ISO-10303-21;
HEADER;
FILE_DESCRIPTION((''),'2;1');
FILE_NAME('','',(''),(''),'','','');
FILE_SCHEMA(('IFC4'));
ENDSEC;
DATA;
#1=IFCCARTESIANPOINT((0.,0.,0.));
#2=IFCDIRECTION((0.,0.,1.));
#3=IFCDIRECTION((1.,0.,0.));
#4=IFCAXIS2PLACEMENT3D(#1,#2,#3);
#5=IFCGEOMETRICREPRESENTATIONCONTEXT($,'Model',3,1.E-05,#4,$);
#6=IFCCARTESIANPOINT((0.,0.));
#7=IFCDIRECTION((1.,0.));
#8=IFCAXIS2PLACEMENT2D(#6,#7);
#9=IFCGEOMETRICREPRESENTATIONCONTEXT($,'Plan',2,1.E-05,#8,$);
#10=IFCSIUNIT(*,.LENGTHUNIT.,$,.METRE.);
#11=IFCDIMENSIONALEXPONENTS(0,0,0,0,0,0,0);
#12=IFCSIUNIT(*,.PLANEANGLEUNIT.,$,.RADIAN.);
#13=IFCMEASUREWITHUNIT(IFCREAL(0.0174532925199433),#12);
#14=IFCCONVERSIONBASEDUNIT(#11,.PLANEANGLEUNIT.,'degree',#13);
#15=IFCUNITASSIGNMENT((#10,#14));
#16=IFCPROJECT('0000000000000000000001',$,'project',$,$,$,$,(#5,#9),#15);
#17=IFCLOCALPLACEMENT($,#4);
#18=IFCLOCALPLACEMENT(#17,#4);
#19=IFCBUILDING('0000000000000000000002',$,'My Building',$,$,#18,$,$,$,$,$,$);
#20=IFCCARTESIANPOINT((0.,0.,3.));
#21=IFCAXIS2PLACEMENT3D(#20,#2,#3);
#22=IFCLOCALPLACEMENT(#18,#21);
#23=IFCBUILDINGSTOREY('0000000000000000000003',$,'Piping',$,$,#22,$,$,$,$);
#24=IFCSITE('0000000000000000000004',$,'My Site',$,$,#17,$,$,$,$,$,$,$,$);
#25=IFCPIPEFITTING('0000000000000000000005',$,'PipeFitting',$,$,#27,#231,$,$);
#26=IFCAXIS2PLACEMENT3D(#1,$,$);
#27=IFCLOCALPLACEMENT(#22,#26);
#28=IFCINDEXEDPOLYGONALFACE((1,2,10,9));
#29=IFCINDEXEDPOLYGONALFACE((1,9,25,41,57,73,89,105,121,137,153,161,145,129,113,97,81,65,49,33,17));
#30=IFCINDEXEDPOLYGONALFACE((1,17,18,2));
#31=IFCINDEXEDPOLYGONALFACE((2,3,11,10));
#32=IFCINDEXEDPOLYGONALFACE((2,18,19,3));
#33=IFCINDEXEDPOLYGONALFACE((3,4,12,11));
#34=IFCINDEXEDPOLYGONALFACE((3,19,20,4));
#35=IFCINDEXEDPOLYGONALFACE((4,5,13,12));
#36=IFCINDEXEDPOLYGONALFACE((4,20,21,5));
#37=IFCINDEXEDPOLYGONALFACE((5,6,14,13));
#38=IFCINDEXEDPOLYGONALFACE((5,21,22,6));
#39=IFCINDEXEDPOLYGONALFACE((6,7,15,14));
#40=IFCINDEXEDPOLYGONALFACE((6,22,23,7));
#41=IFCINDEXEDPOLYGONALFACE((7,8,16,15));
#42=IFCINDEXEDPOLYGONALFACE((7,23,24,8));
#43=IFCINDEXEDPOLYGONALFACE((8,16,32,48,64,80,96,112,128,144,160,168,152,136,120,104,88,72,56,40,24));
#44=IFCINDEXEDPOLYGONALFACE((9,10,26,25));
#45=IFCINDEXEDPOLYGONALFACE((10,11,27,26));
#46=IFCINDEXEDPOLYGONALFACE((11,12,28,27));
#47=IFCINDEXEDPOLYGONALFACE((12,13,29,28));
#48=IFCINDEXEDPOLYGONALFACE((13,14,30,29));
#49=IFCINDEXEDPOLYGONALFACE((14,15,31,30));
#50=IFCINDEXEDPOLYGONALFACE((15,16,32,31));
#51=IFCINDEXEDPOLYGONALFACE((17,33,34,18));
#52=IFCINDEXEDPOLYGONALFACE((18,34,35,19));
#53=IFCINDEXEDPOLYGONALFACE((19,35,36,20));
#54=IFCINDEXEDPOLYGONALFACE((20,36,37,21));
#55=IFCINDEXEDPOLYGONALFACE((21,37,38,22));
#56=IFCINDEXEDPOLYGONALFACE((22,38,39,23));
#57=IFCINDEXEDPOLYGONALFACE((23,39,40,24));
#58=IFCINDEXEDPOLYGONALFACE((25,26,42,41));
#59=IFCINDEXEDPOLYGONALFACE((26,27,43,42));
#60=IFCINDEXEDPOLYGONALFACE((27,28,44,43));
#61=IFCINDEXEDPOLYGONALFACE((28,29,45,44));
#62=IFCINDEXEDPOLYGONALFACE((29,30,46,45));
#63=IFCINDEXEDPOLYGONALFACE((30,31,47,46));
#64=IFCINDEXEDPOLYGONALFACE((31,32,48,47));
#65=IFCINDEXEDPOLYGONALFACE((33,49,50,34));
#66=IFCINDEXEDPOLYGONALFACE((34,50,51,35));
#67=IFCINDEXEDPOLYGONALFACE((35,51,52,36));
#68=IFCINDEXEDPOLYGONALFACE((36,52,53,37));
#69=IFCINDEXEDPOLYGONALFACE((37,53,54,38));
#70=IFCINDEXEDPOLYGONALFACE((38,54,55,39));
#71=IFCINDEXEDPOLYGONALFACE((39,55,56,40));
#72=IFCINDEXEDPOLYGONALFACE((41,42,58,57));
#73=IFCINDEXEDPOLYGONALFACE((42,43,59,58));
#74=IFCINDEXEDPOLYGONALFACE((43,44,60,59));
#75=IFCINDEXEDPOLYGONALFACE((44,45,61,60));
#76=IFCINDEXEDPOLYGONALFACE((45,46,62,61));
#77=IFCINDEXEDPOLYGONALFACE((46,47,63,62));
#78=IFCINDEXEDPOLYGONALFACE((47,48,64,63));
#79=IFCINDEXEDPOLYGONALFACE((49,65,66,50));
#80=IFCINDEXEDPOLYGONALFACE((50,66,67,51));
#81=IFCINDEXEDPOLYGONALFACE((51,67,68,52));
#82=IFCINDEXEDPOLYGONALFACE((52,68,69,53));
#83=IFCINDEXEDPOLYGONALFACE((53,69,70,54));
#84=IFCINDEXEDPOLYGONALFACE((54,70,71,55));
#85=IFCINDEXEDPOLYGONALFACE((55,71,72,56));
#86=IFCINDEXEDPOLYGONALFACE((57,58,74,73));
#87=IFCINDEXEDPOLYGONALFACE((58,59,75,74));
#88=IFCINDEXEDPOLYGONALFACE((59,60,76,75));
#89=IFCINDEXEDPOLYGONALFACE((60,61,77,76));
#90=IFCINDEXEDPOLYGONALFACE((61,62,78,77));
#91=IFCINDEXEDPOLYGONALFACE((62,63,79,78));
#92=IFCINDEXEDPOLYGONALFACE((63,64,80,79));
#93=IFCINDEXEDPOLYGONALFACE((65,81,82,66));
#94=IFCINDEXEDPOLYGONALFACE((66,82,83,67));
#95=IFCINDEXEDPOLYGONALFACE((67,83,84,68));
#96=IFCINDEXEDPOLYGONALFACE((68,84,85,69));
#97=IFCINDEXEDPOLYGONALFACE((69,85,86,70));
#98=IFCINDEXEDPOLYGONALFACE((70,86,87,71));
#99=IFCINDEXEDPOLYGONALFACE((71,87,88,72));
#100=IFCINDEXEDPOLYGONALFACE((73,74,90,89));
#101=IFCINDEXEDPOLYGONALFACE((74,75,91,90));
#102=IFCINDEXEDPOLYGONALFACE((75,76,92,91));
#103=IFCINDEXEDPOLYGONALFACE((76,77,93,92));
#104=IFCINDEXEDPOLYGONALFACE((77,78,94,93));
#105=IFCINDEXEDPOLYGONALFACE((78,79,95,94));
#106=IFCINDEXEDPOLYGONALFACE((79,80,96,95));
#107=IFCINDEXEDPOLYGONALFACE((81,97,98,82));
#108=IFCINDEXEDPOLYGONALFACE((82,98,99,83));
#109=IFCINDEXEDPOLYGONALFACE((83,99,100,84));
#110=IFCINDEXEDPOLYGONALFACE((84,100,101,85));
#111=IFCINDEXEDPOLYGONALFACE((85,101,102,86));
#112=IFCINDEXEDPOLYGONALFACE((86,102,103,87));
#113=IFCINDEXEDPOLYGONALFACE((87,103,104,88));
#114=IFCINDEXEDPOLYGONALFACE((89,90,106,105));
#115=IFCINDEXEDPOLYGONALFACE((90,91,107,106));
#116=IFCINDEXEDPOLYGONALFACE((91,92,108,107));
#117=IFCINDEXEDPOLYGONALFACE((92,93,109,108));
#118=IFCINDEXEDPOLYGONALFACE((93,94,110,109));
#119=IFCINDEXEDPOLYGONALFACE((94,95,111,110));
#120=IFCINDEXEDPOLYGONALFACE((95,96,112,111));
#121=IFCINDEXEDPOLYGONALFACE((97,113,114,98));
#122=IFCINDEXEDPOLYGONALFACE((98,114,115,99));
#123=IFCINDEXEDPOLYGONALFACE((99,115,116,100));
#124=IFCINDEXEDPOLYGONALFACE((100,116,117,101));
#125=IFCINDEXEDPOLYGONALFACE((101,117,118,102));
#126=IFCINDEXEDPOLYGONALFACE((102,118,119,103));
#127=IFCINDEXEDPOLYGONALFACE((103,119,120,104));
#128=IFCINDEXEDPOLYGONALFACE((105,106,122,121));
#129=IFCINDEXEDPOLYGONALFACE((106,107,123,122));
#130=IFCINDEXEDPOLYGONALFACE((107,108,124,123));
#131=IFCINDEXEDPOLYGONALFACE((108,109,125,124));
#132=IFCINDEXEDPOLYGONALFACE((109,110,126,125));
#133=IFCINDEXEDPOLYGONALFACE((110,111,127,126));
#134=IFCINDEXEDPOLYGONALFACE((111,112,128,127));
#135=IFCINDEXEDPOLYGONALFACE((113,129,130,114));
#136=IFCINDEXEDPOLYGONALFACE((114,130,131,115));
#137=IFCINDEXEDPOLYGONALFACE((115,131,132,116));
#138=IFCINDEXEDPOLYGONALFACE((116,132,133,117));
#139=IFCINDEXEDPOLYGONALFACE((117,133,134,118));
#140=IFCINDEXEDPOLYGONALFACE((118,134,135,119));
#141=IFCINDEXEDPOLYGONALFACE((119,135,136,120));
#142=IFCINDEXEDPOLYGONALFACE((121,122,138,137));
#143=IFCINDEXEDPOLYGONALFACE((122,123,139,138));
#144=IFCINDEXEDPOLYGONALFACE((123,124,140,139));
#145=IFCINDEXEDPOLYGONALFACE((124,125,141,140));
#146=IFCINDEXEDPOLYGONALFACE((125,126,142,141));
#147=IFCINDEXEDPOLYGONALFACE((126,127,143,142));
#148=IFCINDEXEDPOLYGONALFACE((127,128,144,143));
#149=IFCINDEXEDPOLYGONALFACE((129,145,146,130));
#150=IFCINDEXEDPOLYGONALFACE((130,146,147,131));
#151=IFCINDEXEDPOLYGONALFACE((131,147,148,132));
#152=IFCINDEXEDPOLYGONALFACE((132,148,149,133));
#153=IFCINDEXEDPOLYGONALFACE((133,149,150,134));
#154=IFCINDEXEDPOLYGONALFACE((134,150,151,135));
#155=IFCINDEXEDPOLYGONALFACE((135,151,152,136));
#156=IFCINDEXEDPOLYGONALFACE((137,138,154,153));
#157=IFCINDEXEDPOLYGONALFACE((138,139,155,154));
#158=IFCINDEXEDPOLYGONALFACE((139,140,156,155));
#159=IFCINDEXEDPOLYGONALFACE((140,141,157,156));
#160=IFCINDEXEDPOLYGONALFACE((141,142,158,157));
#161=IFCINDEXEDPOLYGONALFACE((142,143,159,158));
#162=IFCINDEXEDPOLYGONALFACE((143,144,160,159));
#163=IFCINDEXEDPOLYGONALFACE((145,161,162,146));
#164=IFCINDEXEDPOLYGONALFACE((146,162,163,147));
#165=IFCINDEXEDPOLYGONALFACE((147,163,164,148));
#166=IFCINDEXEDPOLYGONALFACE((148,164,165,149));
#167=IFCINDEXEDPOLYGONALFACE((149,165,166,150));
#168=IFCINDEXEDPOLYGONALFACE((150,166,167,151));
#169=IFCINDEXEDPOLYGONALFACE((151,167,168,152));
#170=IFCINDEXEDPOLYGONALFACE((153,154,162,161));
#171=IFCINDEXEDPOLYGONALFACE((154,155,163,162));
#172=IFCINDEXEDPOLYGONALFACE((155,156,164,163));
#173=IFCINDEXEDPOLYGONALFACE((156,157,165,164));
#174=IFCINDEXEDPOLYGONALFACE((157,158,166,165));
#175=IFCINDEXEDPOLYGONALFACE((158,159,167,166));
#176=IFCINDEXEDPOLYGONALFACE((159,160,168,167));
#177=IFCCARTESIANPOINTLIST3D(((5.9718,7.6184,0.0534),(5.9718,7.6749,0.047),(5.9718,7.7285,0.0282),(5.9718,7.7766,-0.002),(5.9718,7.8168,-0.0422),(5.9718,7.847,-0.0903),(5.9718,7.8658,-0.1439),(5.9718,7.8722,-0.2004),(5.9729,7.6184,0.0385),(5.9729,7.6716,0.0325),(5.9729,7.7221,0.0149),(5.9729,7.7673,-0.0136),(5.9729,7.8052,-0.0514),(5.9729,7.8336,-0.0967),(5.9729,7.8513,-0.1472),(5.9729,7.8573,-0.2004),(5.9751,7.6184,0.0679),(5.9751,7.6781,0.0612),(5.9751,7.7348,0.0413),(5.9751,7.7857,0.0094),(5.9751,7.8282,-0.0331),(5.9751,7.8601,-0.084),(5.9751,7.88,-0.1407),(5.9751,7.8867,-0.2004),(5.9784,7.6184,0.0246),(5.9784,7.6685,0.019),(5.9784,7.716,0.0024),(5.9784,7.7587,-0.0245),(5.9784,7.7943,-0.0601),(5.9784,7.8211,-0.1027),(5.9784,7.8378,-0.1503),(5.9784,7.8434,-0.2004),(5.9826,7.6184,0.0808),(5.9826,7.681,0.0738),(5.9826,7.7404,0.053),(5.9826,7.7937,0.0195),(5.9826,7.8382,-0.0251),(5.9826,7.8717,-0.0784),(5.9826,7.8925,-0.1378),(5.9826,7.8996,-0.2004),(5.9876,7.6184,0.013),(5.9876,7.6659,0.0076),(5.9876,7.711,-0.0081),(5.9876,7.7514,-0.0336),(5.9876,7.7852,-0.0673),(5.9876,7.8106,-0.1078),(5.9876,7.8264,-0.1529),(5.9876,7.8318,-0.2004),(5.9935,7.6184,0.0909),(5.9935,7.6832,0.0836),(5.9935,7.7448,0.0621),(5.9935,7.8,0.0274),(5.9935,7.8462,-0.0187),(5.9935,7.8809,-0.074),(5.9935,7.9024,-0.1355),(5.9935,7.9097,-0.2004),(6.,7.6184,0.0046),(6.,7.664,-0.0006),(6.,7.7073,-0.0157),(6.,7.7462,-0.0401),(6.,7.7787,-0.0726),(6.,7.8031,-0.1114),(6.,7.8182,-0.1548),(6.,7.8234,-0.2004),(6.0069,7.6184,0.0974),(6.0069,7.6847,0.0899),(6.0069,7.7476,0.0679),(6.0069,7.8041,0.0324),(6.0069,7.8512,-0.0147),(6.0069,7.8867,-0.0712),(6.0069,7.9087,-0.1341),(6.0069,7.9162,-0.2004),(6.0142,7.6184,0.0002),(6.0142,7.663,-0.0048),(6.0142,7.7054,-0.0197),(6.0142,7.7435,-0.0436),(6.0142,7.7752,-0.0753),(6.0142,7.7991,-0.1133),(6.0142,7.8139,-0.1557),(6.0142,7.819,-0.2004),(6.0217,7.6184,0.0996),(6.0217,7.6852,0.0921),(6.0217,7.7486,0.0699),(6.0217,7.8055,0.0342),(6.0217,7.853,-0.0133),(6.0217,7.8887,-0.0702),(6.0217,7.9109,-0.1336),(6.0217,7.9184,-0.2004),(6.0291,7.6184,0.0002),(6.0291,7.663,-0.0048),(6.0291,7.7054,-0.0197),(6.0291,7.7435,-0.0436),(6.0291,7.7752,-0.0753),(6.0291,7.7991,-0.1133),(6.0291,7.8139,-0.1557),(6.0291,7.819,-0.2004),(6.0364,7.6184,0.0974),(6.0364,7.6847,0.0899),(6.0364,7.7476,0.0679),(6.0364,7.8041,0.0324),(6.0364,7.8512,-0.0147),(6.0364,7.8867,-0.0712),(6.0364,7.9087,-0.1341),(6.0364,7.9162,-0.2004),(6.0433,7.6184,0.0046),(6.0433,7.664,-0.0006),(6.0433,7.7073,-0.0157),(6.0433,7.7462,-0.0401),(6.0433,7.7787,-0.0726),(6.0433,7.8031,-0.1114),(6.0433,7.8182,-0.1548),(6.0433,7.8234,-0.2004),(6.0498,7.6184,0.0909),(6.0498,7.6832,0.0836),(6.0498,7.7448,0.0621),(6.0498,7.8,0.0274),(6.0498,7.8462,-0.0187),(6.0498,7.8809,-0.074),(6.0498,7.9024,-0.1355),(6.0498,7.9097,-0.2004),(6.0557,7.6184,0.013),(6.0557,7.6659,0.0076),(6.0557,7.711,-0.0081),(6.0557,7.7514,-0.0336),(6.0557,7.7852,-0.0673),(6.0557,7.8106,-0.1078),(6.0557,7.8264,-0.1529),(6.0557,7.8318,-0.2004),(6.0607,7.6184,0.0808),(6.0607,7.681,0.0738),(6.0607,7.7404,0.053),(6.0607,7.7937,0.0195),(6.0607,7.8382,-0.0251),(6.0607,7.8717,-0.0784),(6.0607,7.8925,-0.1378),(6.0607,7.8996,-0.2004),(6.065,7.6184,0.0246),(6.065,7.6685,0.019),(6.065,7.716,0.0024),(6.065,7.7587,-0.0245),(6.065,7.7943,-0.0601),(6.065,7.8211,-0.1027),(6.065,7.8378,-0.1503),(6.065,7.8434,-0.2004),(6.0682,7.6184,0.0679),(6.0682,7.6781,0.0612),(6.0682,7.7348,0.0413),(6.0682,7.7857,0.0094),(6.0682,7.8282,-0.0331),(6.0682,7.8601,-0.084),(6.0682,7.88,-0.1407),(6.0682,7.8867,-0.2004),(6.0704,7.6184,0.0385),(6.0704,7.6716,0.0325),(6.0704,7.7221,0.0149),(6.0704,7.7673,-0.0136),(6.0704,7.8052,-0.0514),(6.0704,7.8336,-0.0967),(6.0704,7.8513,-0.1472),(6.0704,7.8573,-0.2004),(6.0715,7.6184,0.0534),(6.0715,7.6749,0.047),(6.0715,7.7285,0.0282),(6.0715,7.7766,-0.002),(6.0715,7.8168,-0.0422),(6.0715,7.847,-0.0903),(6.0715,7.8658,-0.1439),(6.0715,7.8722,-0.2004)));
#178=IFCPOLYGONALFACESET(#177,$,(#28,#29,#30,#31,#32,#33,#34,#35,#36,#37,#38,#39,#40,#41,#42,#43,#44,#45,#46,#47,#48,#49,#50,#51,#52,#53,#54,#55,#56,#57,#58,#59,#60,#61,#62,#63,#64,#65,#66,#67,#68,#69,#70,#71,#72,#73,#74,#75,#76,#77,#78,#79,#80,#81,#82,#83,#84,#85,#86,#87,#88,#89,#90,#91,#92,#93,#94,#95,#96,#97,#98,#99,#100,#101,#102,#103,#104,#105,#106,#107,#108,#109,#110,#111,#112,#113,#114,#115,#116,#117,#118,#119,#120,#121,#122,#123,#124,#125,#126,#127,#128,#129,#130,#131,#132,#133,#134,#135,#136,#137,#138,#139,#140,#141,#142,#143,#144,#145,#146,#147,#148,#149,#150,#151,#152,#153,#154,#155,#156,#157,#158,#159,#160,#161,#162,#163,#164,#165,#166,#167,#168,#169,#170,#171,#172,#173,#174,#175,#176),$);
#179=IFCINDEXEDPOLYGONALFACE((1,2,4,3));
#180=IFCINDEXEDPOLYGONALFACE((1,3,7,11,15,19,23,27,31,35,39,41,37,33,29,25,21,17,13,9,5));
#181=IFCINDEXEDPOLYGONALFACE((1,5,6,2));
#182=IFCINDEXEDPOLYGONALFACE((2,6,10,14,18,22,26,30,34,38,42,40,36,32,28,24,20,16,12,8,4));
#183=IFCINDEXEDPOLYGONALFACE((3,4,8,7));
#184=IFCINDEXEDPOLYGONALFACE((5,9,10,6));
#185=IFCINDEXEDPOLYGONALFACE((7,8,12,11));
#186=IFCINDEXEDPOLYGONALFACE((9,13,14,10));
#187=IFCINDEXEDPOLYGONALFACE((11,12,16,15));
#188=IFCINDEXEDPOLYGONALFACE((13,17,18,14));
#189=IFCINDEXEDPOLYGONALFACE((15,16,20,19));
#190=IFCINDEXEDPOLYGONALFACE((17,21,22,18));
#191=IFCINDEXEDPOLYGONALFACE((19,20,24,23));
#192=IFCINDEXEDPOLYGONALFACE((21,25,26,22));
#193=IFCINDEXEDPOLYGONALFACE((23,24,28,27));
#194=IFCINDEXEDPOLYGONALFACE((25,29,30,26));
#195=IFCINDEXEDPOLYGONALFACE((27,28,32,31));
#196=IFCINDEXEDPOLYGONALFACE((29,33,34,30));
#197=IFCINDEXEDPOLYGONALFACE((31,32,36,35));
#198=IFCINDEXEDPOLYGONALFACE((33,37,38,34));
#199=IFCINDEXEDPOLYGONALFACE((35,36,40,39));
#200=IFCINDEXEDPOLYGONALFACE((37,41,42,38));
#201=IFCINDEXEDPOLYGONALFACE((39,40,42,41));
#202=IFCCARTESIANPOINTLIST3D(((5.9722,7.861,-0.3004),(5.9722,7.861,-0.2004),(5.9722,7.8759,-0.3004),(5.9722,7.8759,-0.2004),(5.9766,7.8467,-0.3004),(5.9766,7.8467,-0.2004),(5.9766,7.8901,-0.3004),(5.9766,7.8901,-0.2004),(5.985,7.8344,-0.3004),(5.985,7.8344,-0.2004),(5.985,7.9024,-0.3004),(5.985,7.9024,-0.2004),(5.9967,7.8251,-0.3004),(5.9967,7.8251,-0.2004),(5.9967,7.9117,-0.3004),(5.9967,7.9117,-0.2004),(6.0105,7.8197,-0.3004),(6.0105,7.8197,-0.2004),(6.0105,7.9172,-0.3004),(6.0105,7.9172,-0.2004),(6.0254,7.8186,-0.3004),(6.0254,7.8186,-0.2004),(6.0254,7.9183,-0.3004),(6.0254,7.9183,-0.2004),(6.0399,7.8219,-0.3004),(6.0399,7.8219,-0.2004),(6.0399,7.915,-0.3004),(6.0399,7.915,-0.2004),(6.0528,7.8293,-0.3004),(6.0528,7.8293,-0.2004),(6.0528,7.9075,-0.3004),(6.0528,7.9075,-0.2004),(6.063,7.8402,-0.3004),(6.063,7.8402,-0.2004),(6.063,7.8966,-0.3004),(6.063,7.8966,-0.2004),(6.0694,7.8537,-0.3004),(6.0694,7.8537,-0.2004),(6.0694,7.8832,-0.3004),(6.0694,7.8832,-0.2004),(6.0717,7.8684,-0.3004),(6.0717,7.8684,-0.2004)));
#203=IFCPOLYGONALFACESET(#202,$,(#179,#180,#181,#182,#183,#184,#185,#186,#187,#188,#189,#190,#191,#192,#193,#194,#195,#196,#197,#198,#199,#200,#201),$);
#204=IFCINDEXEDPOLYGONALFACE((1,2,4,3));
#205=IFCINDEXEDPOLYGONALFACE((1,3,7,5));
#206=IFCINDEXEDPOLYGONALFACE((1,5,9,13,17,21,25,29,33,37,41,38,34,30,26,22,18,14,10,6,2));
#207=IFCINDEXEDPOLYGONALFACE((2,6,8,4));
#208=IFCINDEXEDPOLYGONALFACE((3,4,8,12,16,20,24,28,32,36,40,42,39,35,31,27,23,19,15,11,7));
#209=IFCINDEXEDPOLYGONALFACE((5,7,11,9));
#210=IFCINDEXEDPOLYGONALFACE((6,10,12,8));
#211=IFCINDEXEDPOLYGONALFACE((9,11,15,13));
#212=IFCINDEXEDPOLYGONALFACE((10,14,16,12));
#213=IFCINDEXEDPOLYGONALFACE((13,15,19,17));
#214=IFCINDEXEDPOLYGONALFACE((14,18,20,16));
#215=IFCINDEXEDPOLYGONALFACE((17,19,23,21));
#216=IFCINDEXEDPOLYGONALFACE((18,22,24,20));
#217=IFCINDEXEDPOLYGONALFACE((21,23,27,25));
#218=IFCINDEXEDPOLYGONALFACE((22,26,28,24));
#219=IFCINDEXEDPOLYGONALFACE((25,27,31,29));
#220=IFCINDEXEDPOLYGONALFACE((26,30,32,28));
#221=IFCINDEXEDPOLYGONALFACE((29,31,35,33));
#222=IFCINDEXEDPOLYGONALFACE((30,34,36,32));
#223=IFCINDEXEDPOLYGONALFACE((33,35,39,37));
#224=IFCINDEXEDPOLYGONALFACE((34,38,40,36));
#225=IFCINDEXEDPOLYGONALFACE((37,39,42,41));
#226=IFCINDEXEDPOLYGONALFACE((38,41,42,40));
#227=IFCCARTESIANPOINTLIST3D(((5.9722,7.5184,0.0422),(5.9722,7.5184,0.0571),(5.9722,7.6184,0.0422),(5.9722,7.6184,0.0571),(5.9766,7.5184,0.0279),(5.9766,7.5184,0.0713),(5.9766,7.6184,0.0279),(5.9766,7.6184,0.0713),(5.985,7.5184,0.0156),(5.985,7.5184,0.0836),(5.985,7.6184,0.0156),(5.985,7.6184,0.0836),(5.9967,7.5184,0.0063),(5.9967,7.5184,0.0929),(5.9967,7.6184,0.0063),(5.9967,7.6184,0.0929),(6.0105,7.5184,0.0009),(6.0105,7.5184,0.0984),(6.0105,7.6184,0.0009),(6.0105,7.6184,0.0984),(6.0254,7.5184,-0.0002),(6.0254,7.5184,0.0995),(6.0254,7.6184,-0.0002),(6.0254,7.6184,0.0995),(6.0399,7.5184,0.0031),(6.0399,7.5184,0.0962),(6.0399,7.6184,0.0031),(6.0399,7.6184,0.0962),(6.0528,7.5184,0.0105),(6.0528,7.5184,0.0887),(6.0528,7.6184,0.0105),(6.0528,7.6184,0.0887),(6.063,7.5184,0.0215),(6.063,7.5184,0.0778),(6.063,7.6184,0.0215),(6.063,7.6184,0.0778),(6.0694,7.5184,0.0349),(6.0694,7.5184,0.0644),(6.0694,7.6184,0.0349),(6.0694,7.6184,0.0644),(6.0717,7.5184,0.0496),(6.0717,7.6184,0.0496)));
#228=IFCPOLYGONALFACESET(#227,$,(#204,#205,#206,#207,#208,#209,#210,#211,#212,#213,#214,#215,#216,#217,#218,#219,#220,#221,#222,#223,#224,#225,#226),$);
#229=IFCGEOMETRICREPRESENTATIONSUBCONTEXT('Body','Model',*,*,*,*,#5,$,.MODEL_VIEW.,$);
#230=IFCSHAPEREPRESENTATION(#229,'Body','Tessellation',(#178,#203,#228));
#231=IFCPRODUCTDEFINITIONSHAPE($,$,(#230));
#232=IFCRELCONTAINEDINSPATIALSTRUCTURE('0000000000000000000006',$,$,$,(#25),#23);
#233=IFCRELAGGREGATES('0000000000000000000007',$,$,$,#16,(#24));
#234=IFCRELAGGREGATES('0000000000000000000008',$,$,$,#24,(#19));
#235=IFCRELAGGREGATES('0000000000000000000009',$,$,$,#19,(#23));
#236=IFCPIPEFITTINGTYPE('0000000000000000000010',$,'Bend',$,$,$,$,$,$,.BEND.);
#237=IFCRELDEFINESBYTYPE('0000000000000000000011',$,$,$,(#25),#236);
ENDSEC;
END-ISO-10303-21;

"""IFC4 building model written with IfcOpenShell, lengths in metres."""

from ifc_helpers import new_model, entity, si_unit, converted_unit, frame, origin_with_axes, origin_2d_with_axis, place, context, subcontext, project, spatial, circle, extrude, source, transform, mapped, type_object, type_shapes, element, save


model = new_model("IFC4")

# Units and contexts
model_context = context("Model", 3, precision=1e-05, world=origin_with_axes())
plan_context = context("Plan", 2, precision=1e-05, world=origin_2d_with_axis())
body_context = subcontext(model_context, "Body", "Model", "MODEL_VIEW")
ifc_project = project(units=[si_unit("LENGTHUNIT", "METRE"), converted_unit("PLANEANGLEUNIT", "degree", entity("IfcReal", 0.0174532925199433), si_unit("PLANEANGLEUNIT", "RADIAN"), dimensions=[0, 0, 0, 0, 0, 0, 0])], contexts=[model_context, plan_context])

# Site, building, storey
site_placement = place(None, origin_with_axes())
site = spatial("IfcSite", under=ifc_project, at=site_placement, Name="My Site")
building_placement = place(site_placement, origin_with_axes())
building = spatial("IfcBuilding", under=site, at=building_placement, Name="My Building")
storey_placement = place(building_placement, frame((0.0, 0.0, 3.0), z_axis=(0.0, 0.0, 1.0), x_axis=(1.0, 0.0, 0.0)))
storey = spatial("IfcBuildingStorey", under=building, at=storey_placement, Name="Piping")

# Pipe fitting
pipe_fitting_type = type_object("IfcPipeFittingType", Name="Bend", PredefinedType="BEND")
shared_shape = source(origin_with_axes(), body_context, "Body", "SolidModel", [
    entity("IfcSweptDiskSolid", entity("IfcIndexedPolyCurve", entity("IfcCartesianPointList3D", [[0.0, 0.0, -0.1], [0.0, 0.0732, -0.2768], [0.0, 0.25, -0.35]]), [entity("IfcArcIndex", [1, 2, 3])]), 0.05),
    extrude(circle(Radius=0.05), origin_with_axes(), (0.0, 0.0, -1.0), 0.1),
    extrude(circle(Radius=0.05), frame((0.0, 0.25, -0.35), z_axis=(0.0, 1.0, 0.000007), x_axis=(1.0, 0.0, 0.0)), (0.0, 0.0, 1.0), 0.1),
])
type_shapes(pipe_fitting_type, [shared_shape])
for number, where, z_axis, x_axis, name in (
    (1, (6.0217, 7.8684, -0.3004), (0.0, 0.0, -1.0), (1.0, 0.0, 0.0), "PipeFitting"),
):
    element("IfcPipeFitting", number, at=place(storey_placement, frame(where, z_axis=z_axis, x_axis=x_axis)), inside=storey, type_object=pipe_fitting_type, Name=name, context=body_context, shape_type="MappedRepresentation", body=[
        mapped(shared_shape, transform((0.0, 0.0, 0.0), x_axis=(1.0, 0.0, 0.0), y_axis=(0.0, 1.0, 0.0), z_axis=(0.0, 0.0, 1.0), scale=1.0)),
    ])

save(model, "model.ifc")
